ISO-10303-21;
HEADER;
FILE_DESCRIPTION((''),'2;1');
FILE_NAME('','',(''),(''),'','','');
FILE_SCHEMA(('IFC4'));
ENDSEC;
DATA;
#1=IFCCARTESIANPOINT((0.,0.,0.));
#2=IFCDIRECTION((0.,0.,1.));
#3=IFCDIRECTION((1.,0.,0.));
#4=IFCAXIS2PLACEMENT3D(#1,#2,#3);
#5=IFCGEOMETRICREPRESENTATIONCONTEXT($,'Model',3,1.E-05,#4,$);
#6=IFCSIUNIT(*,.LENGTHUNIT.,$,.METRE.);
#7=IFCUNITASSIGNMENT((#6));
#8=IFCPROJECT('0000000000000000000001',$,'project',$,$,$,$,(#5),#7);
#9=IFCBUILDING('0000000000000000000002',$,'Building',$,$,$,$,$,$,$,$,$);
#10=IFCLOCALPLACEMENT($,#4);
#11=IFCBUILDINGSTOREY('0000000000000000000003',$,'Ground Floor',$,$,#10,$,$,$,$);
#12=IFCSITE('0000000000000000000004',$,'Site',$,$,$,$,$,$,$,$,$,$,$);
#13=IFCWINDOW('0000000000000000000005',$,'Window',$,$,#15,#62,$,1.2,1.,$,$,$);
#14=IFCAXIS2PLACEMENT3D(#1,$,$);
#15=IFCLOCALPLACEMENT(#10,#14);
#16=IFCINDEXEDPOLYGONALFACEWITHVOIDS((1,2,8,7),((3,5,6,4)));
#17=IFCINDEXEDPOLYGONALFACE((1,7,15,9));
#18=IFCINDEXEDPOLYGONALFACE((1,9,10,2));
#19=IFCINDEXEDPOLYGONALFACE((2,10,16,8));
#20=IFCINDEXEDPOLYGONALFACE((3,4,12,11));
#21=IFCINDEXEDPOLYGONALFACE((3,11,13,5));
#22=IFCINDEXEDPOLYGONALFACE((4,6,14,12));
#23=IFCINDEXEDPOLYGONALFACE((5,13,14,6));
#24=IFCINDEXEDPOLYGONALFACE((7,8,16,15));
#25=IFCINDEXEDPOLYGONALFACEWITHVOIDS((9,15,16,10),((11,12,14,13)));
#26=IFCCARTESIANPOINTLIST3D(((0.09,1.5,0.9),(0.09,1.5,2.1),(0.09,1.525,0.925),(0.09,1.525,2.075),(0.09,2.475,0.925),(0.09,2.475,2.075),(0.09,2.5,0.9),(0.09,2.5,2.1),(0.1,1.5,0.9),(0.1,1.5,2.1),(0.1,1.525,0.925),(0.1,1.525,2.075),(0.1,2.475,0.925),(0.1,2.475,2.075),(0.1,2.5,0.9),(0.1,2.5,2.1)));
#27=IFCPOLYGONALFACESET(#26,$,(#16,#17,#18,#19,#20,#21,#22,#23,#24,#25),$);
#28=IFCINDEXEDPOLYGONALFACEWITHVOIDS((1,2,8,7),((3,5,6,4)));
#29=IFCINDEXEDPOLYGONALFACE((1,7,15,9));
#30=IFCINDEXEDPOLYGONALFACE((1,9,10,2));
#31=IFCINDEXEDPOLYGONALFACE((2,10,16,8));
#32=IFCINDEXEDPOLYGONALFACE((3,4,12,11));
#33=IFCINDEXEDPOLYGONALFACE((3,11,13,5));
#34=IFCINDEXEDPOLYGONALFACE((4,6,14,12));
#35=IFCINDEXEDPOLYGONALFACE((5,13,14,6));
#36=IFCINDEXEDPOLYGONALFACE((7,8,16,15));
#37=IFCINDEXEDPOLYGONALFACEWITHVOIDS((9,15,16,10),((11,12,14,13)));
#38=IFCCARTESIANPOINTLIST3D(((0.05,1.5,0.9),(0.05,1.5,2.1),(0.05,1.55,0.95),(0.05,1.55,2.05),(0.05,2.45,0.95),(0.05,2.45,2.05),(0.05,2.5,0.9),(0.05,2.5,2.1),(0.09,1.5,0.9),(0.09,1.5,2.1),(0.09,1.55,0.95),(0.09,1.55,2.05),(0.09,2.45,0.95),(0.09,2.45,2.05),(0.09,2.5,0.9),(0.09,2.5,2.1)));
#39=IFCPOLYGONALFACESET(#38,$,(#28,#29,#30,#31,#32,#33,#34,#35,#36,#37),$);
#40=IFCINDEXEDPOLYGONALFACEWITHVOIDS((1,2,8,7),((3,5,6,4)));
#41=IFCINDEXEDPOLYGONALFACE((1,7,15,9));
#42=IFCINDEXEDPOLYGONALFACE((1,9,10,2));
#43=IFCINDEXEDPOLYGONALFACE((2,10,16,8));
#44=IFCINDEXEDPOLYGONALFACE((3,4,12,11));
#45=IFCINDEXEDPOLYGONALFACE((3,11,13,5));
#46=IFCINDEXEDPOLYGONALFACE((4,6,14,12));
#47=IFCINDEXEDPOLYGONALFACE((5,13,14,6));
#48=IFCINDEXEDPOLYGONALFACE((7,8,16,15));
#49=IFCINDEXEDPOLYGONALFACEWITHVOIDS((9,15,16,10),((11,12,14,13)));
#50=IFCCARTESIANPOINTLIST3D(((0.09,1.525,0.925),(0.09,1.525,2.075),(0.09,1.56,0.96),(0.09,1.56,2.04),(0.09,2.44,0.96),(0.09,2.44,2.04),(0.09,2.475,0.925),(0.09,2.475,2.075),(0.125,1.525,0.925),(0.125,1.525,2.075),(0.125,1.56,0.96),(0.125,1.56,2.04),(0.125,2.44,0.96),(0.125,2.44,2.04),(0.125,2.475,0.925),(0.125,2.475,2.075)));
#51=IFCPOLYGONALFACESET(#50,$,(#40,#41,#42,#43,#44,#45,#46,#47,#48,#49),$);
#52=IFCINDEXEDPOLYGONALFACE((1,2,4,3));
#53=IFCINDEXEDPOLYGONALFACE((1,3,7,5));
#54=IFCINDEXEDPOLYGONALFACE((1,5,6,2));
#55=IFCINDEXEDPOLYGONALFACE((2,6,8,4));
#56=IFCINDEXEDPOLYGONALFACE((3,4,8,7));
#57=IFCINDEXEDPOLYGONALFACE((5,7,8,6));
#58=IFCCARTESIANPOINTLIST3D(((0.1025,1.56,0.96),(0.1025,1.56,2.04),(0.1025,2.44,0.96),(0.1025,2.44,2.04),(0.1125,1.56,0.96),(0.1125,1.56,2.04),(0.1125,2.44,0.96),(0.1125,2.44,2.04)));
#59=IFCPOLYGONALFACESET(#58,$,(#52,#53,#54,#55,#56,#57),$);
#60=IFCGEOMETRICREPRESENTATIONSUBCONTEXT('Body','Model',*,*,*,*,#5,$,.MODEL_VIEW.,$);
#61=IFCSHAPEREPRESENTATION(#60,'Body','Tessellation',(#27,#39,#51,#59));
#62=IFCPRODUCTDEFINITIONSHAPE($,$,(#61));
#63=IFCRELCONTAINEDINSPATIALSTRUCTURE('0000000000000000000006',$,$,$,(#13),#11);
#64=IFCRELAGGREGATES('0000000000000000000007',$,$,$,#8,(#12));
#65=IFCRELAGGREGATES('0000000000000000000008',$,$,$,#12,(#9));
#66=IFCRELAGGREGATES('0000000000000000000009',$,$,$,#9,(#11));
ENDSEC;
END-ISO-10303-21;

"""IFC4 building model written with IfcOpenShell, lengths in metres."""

from ifc_helpers import new_model, si_unit, frame, origin_with_axes, place, context, subcontext, project, spatial, line, indexed_curve, outline, extrude, element, save


model = new_model("IFC4")

# Units and contexts
model_context = context("Model", 3, precision=1e-05, world=origin_with_axes())
body_context = subcontext(model_context, "Body", "Model", "MODEL_VIEW")
ifc_project = project(units=[si_unit("LENGTHUNIT", "METRE")], contexts=[model_context])

# Site, building, storey
site = spatial("IfcSite", under=ifc_project, Name="Site")
building = spatial("IfcBuilding", under=site, Name="Building")
storey_placement = place(None, origin_with_axes())
storey = spatial("IfcBuildingStorey", under=building, at=storey_placement, Name="Ground Floor")

# Window
window_1_placement = place(storey_placement, frame((0.0, 2.5, 0.9), z_axis=(0.0, 0.0, 1.0), x_axis=(0.0, -1.0, 0.0)))
element("IfcWindow", 1, at=window_1_placement, inside=storey, Name="Window", OverallHeight=1.2, OverallWidth=1.0, context=body_context, shape_type="SweptSolid", body=[
    extrude(outline(indexed_curve([(0.0, 0.0), (1.0, 0.0), (1.0, 1.2), (0.0, 1.2)], segments=[line(1, 2, 3, 4, 1)]), holes=[indexed_curve([(0.025, 0.025), (0.975, 0.025), (0.975, 1.175), (0.025, 1.175)], segments=[line(1, 2, 3, 4, 1)])]), frame((0.0, 0.09, 0.0), z_axis=(0.0, -1.0, 0.0), x_axis=(1.0, 0.0, 0.0)), (0.0, 0.0, -1.0), 0.01),
    extrude(outline(indexed_curve([(0.0, 0.0), (1.0, 0.0), (1.0, 1.2), (0.0, 1.2)], segments=[line(1, 2, 3, 4, 1)]), holes=[indexed_curve([(0.05, 0.05), (0.95, 0.05), (0.95, 1.15), (0.05, 1.15)], segments=[line(1, 2, 3, 4, 1)])]), frame((0.0, 0.05, 0.0), z_axis=(0.0, -1.0, 0.0), x_axis=(1.0, 0.0, 0.0)), (0.0, 0.0, -1.0), 0.04),
    extrude(outline(indexed_curve([(0.0, 0.0), (0.95, 0.0), (0.95, 1.15), (0.0, 1.15)], segments=[line(1, 2, 3, 4, 1)]), holes=[indexed_curve([(0.035, 0.035), (0.915, 0.035), (0.915, 1.115), (0.035, 1.115)], segments=[line(1, 2, 3, 4, 1)])]), frame((0.025, 0.09, 0.025), z_axis=(0.0, -1.0, 0.0), x_axis=(1.0, 0.0, 0.0)), (0.0, 0.0, -1.0), 0.035),
    extrude(outline(indexed_curve([(0.035, 0.035), (0.915, 0.035), (0.915, 1.115), (0.035, 1.115)], segments=[line(1, 2, 3, 4, 1)])), frame((0.025, 0.1025, 0.025), z_axis=(0.0, -1.0, 0.0), x_axis=(1.0, 0.0, 0.0)), (0.0, 0.0, -1.0), 0.01),
])

save(model, "model.ifc")
